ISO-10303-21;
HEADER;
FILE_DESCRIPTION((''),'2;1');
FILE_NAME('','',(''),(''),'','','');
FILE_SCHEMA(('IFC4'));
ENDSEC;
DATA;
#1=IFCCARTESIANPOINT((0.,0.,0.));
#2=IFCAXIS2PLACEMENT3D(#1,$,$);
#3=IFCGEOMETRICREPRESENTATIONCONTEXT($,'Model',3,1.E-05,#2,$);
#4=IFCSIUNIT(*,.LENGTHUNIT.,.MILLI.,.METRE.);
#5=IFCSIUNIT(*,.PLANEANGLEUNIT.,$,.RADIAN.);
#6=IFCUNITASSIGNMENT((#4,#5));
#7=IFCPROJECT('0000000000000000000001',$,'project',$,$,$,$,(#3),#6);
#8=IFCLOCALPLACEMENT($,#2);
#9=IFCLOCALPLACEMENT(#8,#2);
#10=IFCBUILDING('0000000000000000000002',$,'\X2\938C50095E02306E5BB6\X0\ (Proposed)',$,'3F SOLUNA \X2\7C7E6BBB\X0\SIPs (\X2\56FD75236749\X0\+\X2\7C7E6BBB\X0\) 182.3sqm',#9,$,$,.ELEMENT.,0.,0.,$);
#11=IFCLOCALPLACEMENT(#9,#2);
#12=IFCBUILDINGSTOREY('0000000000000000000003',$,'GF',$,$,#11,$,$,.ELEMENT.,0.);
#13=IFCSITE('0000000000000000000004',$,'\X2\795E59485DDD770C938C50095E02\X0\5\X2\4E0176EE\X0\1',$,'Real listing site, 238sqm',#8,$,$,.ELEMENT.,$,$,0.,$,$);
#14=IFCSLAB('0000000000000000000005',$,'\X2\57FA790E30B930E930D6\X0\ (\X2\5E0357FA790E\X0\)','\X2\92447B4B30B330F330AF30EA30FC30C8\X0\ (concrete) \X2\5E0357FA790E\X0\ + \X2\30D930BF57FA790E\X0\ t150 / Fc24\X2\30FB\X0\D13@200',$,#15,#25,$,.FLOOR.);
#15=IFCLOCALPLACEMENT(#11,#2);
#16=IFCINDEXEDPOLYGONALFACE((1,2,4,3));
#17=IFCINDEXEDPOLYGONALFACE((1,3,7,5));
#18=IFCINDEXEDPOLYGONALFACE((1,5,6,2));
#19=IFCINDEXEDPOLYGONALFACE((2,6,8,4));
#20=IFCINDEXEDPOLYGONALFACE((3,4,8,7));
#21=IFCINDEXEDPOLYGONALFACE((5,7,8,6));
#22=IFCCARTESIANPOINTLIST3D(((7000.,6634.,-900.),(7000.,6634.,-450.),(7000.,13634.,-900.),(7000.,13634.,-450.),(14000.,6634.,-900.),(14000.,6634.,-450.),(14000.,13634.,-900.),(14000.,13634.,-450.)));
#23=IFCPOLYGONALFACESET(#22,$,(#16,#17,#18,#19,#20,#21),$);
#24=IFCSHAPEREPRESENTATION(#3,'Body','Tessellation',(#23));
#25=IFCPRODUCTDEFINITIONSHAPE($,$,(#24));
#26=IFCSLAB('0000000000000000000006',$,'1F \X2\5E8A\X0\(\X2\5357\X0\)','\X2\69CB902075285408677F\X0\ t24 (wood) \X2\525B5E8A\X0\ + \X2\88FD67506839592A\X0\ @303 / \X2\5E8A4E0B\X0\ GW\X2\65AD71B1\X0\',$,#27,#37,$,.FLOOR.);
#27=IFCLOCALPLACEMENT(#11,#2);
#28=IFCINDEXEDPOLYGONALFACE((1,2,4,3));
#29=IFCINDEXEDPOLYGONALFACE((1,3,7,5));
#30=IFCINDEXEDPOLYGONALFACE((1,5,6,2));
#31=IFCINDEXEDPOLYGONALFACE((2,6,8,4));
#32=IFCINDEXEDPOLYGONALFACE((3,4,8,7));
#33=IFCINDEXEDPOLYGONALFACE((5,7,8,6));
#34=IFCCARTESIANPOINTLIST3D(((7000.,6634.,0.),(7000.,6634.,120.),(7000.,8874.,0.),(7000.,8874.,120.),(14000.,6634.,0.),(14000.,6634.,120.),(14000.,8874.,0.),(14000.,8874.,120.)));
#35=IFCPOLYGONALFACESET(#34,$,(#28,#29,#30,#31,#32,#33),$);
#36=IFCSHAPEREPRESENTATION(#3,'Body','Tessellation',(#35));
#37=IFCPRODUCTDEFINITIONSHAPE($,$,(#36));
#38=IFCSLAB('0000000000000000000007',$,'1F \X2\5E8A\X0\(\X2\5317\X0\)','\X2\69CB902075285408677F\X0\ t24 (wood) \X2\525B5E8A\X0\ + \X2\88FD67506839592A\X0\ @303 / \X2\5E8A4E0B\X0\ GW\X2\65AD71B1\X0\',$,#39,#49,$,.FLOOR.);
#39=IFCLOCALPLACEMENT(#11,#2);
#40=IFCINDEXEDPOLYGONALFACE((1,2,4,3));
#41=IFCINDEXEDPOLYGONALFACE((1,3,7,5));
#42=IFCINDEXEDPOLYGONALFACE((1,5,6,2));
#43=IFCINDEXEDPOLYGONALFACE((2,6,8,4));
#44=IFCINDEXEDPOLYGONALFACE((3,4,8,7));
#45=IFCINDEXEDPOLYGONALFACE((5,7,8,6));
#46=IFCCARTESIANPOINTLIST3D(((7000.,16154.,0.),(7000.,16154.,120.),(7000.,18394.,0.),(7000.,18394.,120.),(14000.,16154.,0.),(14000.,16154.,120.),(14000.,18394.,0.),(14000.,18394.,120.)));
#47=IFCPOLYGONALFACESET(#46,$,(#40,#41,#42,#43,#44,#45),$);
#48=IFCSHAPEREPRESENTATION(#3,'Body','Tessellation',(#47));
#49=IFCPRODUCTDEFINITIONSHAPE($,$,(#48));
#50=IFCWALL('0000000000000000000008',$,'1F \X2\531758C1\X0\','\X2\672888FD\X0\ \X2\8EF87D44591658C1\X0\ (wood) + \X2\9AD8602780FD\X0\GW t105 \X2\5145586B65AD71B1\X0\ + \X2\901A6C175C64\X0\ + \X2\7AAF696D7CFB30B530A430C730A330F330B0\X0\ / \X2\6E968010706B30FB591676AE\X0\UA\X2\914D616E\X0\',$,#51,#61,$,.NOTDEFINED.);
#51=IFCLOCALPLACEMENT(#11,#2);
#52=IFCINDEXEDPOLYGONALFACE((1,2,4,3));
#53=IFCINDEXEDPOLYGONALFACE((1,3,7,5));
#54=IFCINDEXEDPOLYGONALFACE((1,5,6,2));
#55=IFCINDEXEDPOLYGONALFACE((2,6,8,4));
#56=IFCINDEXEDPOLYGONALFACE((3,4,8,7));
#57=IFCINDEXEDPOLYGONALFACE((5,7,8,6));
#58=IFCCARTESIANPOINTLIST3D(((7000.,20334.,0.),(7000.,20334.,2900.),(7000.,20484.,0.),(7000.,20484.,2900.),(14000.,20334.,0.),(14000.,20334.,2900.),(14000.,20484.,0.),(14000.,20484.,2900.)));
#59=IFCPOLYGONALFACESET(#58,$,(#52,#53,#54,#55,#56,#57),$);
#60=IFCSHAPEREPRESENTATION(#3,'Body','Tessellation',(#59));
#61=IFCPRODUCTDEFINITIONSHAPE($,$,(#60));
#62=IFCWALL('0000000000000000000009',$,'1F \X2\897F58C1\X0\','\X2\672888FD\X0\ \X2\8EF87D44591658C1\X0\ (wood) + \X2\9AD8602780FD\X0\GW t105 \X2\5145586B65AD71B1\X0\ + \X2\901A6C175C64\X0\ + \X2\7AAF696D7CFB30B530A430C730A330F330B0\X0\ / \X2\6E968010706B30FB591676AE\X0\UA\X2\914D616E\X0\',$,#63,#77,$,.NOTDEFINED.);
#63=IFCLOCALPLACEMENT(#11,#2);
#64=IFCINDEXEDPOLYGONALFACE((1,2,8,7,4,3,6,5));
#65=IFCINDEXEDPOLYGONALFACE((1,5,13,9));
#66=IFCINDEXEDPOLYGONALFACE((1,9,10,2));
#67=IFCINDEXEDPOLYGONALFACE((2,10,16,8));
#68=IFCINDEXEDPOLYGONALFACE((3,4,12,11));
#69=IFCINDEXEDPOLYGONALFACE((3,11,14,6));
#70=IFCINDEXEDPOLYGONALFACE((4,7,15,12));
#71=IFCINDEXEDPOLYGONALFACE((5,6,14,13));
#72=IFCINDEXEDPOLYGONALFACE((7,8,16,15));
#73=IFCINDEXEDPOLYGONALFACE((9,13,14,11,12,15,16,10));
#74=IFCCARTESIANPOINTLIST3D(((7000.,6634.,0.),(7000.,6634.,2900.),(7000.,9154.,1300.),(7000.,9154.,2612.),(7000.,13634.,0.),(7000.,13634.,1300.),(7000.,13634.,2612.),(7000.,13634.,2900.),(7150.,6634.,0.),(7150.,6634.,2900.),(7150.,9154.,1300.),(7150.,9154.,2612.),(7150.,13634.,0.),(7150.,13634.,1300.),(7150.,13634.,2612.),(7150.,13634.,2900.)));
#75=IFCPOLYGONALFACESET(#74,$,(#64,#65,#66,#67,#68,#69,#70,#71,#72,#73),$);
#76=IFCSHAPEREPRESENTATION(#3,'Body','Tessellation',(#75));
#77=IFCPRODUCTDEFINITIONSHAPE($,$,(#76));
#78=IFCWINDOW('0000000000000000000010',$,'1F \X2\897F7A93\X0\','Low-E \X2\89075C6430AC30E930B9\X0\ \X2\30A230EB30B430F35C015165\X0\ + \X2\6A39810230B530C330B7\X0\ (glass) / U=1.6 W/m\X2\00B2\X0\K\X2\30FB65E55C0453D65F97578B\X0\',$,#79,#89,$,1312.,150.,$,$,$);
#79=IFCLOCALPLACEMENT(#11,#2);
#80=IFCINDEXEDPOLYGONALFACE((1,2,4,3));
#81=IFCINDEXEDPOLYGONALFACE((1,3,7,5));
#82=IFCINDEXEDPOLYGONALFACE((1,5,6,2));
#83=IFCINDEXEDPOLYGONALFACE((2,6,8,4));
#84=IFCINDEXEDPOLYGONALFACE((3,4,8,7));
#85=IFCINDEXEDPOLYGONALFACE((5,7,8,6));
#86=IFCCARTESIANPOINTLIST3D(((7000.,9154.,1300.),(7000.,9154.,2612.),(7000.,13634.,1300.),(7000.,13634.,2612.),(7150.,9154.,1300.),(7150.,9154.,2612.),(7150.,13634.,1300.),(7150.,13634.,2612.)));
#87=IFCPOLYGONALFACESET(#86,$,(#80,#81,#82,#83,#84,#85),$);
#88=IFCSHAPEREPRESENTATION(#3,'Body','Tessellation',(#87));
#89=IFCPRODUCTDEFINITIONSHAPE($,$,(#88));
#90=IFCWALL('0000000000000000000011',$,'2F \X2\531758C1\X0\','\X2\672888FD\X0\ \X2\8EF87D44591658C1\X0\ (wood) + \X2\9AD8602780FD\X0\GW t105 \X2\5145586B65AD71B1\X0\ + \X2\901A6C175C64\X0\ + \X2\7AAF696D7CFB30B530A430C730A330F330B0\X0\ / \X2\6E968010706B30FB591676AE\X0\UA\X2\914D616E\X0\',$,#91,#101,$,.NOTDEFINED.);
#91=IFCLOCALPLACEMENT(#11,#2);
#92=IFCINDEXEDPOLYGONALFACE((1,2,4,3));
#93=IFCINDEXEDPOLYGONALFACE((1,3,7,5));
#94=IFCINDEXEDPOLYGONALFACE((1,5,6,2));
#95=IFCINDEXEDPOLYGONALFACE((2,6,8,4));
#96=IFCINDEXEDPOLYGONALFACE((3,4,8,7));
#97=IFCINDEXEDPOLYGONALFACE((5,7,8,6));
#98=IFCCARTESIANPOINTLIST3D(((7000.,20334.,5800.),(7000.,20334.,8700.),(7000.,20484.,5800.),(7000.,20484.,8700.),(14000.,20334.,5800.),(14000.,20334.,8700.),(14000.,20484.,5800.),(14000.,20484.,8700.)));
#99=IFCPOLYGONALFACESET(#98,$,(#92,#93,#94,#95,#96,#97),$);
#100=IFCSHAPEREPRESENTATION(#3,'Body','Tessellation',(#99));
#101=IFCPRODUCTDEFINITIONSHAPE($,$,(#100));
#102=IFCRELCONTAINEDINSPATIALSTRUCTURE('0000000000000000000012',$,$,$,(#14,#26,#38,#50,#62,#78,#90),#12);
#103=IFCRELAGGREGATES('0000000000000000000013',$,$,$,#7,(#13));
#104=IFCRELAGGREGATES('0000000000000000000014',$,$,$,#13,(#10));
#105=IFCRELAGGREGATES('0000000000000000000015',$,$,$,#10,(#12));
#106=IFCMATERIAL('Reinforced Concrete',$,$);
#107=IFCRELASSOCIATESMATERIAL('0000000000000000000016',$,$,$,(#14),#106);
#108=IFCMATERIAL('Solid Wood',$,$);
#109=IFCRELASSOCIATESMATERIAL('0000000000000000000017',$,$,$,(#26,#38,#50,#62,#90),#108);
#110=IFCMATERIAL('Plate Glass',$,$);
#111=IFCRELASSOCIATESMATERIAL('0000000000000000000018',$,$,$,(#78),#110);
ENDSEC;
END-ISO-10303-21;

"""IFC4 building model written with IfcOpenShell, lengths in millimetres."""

from ifc_helpers import new_model, si_unit, frame, frame_2d, origin, place, context, project, spatial, rectangle, extrude, material, element, fill, save


model = new_model("IFC4")

# Units and contexts
model_context = context("Model", 3, precision=1e-05, world=origin())
ifc_project = project(units=[si_unit("LENGTHUNIT", "METRE", prefix="MILLI"), si_unit("PLANEANGLEUNIT", "RADIAN")], contexts=[model_context])

# Site, building, storey
site_placement = place(None, origin())
site = spatial("IfcSite", under=ifc_project, at=site_placement, Name="神奈川県鎌倉市5丁目1", ObjectType="Real listing site, 238sqm", CompositionType="ELEMENT", RefElevation=0.0)
building_placement = place(site_placement, origin())
building = spatial("IfcBuilding", under=site, at=building_placement, Name="鎌倉市の家 (Proposed)", ObjectType="3F SOLUNA 籾殻SIPs (国産杉+籾殻) 182.3sqm", CompositionType="ELEMENT", ElevationOfRefHeight=0.0, ElevationOfTerrain=0.0)
storey_placement = place(building_placement, origin())
storey = spatial("IfcBuildingStorey", under=building, at=storey_placement, Name="GF", CompositionType="ELEMENT", Elevation=0.0)

# Slabs
ifc_material_1 = material(Name="Reinforced Concrete")
slab_1_placement = place(storey_placement, frame((3500.0, 3317.0, -450.0)))
element("IfcSlab", 1, at=slab_1_placement, inside=storey, material=ifc_material_1, Name="基礎スラブ (布基礎)", Description="鉄筋コンクリート (concrete) 布基礎 + ベタ基礎 t150 / Fc24・D13@200", PredefinedType="FLOOR", context=model_context, shape_type="SweptSolid", body=[
    extrude(rectangle(XDim=7000.0, YDim=7000.0, at=frame_2d((3500.0, 3500.0))), frame((3500.0, 3317.0, -450.0)), (0.0, 0.0, 1.0), 450.0),
])
ifc_material_2 = material(Name="Solid Wood")
slab_2_placement = place(storey_placement, frame((3500.0, 3317.0, 0.0)))
element("IfcSlab", 2, at=slab_2_placement, inside=storey, material=ifc_material_2, Name="1F 床(南)", Description="構造用合板 t24 (wood) 剛床 + 製材根太 @303 / 床下 GW断熱", PredefinedType="FLOOR", context=model_context, shape_type="SweptSolid", body=[
    extrude(rectangle(XDim=7000.0, YDim=2240.0, at=frame_2d((3500.0, 1120.0))), frame((3500.0, 3317.0, 0.0)), (0.0, 0.0, 1.0), 120.0),
])
slab_3_placement = place(storey_placement, frame((3500.0, 8077.0, 0.0)))
element("IfcSlab", 3, at=slab_3_placement, inside=storey, material=ifc_material_2, Name="1F 床(北)", Description="構造用合板 t24 (wood) 剛床 + 製材根太 @303 / 床下 GW断熱", PredefinedType="FLOOR", context=model_context, shape_type="SweptSolid", body=[
    extrude(rectangle(XDim=7000.0, YDim=2240.0, at=frame_2d((3500.0, 1120.0))), frame((3500.0, 8077.0, 0.0)), (0.0, 0.0, 1.0), 120.0),
])

# Shared definitions
ifc_material_3 = material(Name="Plate Glass")

# Wall
wall_1_placement = place(storey_placement, frame((3500.0, 10167.0, 0.0)))
element("IfcWall", 4, at=wall_1_placement, inside=storey, material=ifc_material_2, Name="1F 北壁", Description="木製 軸組外壁 (wood) + 高性能GW t105 充填断熱 + 通気層 + 窯業系サイディング / 準耐火・外皮UA配慮", PredefinedType="NOTDEFINED", context=model_context, shape_type="SweptSolid", body=[
    extrude(rectangle(XDim=7000.0, YDim=150.0, at=frame_2d((3500.0, 75.0))), frame((3500.0, 10167.0, 0.0)), (0.0, 0.0, 1.0), 2900.0),
])

# Wall, opening, window
wall_2_placement = place(storey_placement, frame((3500.0, 3317.0, 0.0)))
wall_2 = element("IfcWall", 5, at=wall_2_placement, inside=storey, material=ifc_material_2, Name="1F 西壁", Description="木製 軸組外壁 (wood) + 高性能GW t105 充填断熱 + 通気層 + 窯業系サイディング / 準耐火・外皮UA配慮", PredefinedType="NOTDEFINED", context=model_context, shape_type="SweptSolid", body=[
    extrude(rectangle(XDim=150.0, YDim=7000.0, at=frame_2d((75.0, 3500.0))), frame((3500.0, 3317.0, 0.0)), (0.0, 0.0, 1.0), 2900.0),
])
opening_1_placement = place(storey_placement, frame((3500.0, 4577.0, 650.0)))
opening_1 = element("IfcOpeningElement", 6, at=opening_1_placement, cuts=wall_2, PredefinedType="NOTDEFINED", context=model_context, shape_type="SweptSolid", body=[
    extrude(rectangle(XDim=150.0, YDim=4480.0, at=frame_2d((75.0, 2240.0))), frame((3500.0, 4577.0, 650.0)), (0.0, 0.0, 1.0), 1312.0),
])
window_1_placement = place(storey_placement, frame((3500.0, 4577.0, 650.0)))
window_1 = element("IfcWindow", 7, at=window_1_placement, inside=storey, material=ifc_material_3, Name="1F 西窓", Description="Low-E 複層ガラス アルゴン封入 + 樹脂サッシ (glass) / U=1.6 W/m²K・日射取得型", OverallHeight=1312.0, OverallWidth=150.0, context=model_context, shape_type="SweptSolid", body=[
    extrude(rectangle(XDim=150.0, YDim=4480.0, at=frame_2d((75.0, 2240.0))), frame((3500.0, 4577.0, 650.0)), (0.0, 0.0, 1.0), 1312.0),
])
fill(opening_1, window_1)

# Wall
wall_3_placement = place(storey_placement, frame((3500.0, 10167.0, 2900.0)))
element("IfcWall", 8, at=wall_3_placement, inside=storey, material=ifc_material_2, Name="2F 北壁", Description="木製 軸組外壁 (wood) + 高性能GW t105 充填断熱 + 通気層 + 窯業系サイディング / 準耐火・外皮UA配慮", PredefinedType="NOTDEFINED", context=model_context, shape_type="SweptSolid", body=[
    extrude(rectangle(XDim=7000.0, YDim=150.0, at=frame_2d((3500.0, 75.0))), frame((3500.0, 10167.0, 2900.0)), (0.0, 0.0, 1.0), 2900.0),
])

save(model, "model.ifc")
